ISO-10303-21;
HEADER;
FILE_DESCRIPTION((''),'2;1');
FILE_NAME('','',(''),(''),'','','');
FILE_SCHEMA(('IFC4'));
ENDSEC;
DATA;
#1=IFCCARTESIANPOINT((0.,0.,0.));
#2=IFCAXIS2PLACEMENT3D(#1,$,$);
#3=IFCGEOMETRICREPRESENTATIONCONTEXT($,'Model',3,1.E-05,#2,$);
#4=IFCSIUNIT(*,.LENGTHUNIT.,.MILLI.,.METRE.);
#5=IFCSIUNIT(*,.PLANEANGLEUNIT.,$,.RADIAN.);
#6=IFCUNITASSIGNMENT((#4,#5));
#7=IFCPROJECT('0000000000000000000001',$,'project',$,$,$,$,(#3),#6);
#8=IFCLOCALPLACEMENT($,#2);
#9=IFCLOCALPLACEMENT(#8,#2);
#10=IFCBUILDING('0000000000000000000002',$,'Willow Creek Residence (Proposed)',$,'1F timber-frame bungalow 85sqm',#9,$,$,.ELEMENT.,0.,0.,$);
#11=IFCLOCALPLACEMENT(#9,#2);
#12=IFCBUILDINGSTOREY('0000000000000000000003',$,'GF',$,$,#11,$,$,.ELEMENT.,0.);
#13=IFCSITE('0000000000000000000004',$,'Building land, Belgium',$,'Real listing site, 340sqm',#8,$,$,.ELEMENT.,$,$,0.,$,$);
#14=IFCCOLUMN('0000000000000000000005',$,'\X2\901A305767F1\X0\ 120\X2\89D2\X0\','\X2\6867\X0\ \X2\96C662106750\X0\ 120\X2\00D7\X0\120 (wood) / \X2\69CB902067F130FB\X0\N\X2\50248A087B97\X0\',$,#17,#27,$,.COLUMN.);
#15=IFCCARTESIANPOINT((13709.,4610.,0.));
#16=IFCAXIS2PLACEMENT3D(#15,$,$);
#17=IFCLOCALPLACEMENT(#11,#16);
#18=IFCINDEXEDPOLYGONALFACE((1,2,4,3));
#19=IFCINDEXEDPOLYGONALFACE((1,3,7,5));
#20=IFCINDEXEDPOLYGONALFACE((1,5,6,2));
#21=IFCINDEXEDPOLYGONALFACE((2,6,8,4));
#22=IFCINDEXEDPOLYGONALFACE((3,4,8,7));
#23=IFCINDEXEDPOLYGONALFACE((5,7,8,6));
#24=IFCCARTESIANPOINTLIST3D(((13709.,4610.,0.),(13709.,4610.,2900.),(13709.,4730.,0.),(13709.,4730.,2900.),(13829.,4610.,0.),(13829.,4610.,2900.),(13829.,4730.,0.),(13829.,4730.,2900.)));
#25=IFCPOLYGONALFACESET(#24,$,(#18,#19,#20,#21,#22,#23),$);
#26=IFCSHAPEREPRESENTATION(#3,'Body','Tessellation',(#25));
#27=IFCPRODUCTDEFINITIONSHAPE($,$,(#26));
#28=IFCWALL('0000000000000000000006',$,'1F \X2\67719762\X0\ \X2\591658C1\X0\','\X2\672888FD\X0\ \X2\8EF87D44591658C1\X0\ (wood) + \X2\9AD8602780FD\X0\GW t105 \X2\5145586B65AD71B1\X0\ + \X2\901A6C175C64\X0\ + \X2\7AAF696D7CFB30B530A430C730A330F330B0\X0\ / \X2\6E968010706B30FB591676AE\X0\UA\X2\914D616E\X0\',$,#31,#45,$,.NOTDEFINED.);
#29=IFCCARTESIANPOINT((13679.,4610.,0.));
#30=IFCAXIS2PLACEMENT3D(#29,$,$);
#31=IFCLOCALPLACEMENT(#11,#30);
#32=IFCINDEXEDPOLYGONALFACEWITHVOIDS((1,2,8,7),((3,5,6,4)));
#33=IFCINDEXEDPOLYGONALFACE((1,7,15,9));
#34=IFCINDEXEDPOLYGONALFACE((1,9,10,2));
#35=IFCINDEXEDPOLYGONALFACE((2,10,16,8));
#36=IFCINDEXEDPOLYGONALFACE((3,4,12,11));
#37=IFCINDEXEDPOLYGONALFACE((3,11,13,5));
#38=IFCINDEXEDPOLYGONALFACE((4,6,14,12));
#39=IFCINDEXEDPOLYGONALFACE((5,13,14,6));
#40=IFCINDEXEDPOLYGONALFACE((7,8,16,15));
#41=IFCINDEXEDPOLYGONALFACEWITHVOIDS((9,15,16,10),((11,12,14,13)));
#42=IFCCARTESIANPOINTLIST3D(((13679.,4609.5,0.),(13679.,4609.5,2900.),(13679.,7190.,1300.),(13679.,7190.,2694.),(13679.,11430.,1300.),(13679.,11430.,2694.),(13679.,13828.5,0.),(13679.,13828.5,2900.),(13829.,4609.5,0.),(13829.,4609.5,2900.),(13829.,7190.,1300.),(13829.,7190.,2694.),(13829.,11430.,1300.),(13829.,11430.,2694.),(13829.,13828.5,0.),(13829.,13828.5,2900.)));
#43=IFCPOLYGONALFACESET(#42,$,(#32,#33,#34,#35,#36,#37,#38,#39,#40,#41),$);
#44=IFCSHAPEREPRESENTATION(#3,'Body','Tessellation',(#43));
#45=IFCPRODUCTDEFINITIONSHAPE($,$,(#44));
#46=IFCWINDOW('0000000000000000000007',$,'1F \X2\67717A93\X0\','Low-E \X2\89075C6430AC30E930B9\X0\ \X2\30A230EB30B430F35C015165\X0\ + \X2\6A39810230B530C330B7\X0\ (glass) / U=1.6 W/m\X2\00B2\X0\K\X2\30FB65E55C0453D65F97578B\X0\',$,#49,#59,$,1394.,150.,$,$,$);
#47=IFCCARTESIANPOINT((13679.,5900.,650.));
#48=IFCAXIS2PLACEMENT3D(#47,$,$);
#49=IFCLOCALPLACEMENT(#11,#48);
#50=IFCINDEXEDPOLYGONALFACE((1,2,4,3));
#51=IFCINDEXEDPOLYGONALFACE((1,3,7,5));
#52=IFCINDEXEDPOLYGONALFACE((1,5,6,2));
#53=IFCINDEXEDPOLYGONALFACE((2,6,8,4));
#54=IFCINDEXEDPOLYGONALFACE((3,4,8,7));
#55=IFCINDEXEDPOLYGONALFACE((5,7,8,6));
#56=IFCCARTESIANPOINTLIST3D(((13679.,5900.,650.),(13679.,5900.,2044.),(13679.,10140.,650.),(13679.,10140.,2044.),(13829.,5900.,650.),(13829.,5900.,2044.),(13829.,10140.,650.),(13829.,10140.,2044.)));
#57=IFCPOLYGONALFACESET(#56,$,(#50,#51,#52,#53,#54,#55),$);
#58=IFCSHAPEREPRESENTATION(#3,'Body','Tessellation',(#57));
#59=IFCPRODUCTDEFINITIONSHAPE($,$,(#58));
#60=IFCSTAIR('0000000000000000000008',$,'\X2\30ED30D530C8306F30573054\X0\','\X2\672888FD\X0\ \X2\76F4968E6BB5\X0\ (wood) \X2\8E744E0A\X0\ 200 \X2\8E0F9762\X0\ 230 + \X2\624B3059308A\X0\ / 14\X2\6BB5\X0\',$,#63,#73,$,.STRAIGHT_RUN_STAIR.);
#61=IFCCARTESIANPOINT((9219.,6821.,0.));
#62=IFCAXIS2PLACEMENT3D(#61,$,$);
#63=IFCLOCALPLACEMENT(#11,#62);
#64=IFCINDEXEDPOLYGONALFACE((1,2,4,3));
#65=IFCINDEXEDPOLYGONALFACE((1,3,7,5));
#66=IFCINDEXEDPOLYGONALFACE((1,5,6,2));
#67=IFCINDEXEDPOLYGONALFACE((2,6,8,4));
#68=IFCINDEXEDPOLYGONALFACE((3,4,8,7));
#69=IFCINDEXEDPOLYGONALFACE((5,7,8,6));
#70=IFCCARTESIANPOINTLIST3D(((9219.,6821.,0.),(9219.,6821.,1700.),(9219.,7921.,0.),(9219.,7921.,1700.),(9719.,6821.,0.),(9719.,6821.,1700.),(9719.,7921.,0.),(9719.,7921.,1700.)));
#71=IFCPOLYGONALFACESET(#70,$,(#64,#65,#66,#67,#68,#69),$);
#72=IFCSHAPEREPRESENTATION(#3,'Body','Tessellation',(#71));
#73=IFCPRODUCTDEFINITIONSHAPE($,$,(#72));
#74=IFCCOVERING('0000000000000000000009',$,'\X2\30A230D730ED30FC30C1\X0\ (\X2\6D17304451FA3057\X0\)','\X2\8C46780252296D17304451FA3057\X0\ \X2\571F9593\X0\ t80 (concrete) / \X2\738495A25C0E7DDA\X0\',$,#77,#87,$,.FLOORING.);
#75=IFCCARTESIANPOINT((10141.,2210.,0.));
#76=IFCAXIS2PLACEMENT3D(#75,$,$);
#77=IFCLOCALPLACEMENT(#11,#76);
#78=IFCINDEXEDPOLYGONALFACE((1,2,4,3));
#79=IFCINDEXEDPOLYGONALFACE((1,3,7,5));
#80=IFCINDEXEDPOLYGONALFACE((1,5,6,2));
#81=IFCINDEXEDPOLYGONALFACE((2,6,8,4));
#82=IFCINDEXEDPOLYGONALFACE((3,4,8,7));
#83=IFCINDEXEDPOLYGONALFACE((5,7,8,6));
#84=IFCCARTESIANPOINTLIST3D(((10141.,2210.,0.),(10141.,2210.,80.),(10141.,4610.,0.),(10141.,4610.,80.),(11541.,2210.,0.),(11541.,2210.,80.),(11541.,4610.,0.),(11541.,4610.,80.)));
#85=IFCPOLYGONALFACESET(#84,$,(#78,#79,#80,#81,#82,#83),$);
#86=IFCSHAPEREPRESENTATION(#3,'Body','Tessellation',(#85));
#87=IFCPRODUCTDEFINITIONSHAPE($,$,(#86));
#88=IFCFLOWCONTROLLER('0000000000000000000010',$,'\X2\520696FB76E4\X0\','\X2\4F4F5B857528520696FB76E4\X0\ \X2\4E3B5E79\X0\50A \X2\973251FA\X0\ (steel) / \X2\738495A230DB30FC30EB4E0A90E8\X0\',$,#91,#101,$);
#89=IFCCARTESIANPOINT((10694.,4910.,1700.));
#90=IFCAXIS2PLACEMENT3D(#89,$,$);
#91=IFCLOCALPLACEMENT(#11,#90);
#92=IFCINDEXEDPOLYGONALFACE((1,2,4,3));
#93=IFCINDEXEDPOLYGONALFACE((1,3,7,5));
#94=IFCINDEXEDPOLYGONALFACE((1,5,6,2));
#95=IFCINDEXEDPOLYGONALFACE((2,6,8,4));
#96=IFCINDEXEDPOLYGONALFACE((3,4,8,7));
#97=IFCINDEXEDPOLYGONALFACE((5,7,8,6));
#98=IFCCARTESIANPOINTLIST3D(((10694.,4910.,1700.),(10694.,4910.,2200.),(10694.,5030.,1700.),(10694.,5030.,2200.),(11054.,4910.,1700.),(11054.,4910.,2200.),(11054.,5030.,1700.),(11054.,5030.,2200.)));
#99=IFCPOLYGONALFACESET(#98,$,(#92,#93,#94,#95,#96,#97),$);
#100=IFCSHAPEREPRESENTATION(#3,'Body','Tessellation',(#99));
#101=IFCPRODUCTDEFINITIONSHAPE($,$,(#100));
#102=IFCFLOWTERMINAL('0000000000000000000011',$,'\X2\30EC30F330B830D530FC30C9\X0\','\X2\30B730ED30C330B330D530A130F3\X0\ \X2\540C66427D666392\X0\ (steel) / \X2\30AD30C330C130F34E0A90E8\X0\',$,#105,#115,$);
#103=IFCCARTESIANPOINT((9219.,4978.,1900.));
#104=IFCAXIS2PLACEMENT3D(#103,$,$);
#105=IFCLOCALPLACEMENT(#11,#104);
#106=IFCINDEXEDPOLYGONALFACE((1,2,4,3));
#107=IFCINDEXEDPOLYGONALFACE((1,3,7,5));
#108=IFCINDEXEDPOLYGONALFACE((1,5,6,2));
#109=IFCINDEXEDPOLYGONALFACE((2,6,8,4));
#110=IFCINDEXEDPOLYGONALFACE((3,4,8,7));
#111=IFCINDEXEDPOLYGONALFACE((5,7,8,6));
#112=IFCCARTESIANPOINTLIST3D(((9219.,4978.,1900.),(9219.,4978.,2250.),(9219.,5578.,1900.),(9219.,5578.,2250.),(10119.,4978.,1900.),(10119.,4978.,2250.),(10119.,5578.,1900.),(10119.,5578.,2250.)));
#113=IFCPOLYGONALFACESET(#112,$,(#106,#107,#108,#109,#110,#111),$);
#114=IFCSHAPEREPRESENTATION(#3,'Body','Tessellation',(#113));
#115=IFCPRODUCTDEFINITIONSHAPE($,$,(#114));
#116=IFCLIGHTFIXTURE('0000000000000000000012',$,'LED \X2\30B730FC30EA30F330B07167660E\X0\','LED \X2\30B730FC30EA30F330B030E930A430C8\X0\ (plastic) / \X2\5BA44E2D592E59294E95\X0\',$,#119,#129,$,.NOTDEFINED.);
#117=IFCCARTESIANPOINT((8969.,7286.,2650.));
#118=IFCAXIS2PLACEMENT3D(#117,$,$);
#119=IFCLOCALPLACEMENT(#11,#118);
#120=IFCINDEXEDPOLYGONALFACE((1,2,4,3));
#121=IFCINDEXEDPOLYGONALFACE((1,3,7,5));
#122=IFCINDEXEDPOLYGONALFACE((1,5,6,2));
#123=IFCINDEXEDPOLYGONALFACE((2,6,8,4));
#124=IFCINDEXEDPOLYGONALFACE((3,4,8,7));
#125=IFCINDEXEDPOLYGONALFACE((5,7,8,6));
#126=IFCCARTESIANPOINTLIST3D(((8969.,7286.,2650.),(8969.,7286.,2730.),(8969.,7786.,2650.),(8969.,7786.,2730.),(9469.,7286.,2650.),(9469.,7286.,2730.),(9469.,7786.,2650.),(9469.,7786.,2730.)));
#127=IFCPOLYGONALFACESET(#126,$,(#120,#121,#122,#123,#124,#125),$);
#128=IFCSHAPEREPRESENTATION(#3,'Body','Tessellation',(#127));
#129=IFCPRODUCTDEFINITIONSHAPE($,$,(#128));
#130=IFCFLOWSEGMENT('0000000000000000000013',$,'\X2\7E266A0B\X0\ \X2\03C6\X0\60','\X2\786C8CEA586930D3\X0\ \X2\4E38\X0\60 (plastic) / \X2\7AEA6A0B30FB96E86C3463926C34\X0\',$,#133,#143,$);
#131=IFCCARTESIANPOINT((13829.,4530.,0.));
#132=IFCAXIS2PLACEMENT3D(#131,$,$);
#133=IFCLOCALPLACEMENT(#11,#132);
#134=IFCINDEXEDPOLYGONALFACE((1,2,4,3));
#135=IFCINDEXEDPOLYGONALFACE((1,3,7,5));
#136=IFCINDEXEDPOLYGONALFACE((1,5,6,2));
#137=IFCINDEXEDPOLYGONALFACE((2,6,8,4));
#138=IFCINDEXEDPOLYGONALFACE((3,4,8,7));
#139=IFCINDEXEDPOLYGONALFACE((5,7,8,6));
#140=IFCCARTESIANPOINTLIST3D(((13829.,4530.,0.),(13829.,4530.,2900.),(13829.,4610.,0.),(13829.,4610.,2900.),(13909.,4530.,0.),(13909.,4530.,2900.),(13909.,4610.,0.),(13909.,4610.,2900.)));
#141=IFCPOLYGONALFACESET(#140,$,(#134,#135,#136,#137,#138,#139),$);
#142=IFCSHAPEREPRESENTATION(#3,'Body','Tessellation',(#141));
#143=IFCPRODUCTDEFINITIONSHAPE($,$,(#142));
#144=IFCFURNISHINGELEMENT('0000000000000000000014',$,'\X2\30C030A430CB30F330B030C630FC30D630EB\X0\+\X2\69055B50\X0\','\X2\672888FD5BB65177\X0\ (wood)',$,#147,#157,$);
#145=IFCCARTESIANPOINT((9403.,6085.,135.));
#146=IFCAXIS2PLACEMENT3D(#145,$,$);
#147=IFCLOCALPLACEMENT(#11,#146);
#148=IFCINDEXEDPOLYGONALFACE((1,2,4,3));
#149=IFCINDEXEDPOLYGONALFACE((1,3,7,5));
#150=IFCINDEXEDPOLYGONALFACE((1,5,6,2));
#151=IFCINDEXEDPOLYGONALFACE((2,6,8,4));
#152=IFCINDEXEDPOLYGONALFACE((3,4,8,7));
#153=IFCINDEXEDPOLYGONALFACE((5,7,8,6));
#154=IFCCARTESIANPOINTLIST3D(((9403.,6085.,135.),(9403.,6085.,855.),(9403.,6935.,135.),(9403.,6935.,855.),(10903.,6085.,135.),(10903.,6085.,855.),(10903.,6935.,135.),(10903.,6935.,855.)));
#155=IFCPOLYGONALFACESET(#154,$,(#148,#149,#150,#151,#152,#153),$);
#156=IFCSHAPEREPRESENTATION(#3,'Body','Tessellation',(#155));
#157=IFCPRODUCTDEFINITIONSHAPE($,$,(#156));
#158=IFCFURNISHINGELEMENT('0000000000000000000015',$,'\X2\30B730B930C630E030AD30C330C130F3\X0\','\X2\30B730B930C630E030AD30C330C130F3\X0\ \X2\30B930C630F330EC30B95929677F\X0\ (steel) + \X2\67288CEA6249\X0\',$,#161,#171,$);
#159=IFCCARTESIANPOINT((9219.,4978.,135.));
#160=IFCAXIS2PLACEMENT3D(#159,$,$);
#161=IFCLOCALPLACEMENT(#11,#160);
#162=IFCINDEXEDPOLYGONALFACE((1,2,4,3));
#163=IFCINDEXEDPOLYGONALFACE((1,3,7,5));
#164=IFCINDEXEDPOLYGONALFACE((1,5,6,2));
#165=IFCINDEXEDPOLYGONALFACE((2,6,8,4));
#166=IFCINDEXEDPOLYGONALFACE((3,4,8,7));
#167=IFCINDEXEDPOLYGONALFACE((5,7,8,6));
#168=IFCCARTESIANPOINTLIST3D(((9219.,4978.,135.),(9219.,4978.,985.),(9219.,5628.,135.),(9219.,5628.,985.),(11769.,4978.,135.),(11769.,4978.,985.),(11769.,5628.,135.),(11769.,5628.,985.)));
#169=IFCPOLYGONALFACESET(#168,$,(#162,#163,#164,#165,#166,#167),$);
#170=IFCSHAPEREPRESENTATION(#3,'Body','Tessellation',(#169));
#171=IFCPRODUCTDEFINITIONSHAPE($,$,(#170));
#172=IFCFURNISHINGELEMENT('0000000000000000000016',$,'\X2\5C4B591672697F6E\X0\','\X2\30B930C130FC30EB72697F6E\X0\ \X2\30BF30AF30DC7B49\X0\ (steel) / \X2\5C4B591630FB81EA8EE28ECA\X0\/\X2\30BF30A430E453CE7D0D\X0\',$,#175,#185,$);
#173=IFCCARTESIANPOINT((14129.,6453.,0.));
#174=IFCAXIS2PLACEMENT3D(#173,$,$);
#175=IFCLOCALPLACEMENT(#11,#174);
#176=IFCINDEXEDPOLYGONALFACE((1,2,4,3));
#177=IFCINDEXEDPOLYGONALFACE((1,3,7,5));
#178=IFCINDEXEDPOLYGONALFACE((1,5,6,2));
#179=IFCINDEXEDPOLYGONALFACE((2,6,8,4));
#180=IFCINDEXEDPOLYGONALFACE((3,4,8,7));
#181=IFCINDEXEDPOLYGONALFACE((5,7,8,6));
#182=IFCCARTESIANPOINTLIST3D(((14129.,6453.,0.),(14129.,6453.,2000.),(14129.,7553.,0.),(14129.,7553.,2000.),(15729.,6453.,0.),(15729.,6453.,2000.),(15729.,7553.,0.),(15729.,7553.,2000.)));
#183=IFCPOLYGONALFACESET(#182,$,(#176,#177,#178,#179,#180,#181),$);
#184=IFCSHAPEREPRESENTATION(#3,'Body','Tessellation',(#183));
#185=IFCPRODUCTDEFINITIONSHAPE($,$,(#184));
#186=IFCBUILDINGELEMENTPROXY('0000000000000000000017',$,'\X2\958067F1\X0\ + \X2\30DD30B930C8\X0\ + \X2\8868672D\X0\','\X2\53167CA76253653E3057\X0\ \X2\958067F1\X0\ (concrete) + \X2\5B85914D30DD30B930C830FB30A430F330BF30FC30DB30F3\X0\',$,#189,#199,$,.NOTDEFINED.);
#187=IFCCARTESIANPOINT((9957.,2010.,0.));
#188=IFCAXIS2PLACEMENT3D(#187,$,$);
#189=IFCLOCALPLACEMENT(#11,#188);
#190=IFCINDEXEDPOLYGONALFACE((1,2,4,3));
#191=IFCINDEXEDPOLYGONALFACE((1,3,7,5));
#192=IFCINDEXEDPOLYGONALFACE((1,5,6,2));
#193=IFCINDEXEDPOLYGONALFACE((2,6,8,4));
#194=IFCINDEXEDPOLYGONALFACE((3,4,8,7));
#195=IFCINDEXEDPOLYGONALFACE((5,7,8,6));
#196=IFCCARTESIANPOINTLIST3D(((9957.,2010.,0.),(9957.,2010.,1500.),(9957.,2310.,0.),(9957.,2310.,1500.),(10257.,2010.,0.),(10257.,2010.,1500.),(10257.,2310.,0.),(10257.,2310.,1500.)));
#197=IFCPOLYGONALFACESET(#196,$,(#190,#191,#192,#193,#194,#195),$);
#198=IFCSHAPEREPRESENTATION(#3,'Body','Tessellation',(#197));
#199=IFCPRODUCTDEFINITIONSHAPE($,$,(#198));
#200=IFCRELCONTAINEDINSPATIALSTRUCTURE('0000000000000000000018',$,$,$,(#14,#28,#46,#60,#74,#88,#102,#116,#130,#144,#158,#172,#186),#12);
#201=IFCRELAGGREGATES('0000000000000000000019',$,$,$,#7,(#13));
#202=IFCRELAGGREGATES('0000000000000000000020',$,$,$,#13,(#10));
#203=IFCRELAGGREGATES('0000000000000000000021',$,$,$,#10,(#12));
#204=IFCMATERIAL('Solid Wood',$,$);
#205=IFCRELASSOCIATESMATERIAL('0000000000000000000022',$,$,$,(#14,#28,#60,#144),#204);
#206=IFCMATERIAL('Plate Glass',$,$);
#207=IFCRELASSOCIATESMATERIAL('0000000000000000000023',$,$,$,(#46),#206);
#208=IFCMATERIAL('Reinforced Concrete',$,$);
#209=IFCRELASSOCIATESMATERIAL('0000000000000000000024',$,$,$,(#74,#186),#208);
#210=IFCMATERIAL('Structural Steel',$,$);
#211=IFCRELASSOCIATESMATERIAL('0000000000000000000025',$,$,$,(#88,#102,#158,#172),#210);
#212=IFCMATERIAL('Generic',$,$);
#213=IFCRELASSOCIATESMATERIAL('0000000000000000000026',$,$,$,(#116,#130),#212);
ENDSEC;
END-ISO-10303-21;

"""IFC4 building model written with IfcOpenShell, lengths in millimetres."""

from ifc_helpers import new_model, si_unit, frame, frame_2d, origin, place, context, project, spatial, rectangle, extrude, material, element, fill, save


model = new_model("IFC4")

# Units and contexts
model_context = context("Model", 3, precision=1e-05, world=origin())
ifc_project = project(units=[si_unit("LENGTHUNIT", "METRE", prefix="MILLI"), si_unit("PLANEANGLEUNIT", "RADIAN")], contexts=[model_context])

# Site, building, storey
site_placement = place(None, origin())
site = spatial("IfcSite", under=ifc_project, at=site_placement, Name="Building land, Belgium", ObjectType="Real listing site, 340sqm", CompositionType="ELEMENT", RefElevation=0.0)
building_placement = place(site_placement, origin())
building = spatial("IfcBuilding", under=site, at=building_placement, Name="Willow Creek Residence (Proposed)", ObjectType="1F timber-frame bungalow 85sqm", CompositionType="ELEMENT", ElevationOfRefHeight=0.0, ElevationOfTerrain=0.0)
storey_placement = place(building_placement, origin())
storey = spatial("IfcBuildingStorey", under=building, at=storey_placement, Name="GF", CompositionType="ELEMENT", Elevation=0.0)

# Column
ifc_material_1 = material(Name="Solid Wood")
column_1_placement = place(storey_placement, frame((13709.0, 4610.0, 0.0)))
element("IfcColumn", 1, at=column_1_placement, inside=storey, material=ifc_material_1, Name="通し柱 120角", Description="桧 集成材 120×120 (wood) / 構造柱・N値計算", PredefinedType="COLUMN", context=model_context, shape_type="SweptSolid", body=[
    extrude(rectangle(XDim=120.0, YDim=120.0, at=frame_2d((60.0, 60.0))), frame((13709.0, 4610.0, 0.0)), (0.0, 0.0, 1.0), 2900.0),
])

# Wall, opening, window
wall_1_placement = place(storey_placement, frame((13679.0, 4610.0, 0.0)))
wall_1 = element("IfcWall", 2, at=wall_1_placement, inside=storey, material=ifc_material_1, Name="1F 東面 外壁", Description="木製 軸組外壁 (wood) + 高性能GW t105 充填断熱 + 通気層 + 窯業系サイディング / 準耐火・外皮UA配慮", PredefinedType="NOTDEFINED", context=model_context, shape_type="SweptSolid", body=[
    extrude(rectangle(XDim=150.0, YDim=9219.0, at=frame_2d((75.0, 4609.0))), frame((13679.0, 4610.0, 0.0)), (0.0, 0.0, 1.0), 2900.0),
])
opening_placement = place(storey_placement, frame((13679.0, 5900.0, 650.0)))
opening = element("IfcOpeningElement", 3, at=opening_placement, cuts=wall_1, PredefinedType="NOTDEFINED", context=model_context, shape_type="SweptSolid", body=[
    extrude(rectangle(XDim=150.0, YDim=4240.0, at=frame_2d((75.0, 2120.0))), frame((13679.0, 5900.0, 650.0)), (0.0, 0.0, 1.0), 1394.0),
])
ifc_material_2 = material(Name="Plate Glass")
window_placement = place(storey_placement, frame((13679.0, 5900.0, 650.0)))
window = element("IfcWindow", 4, at=window_placement, inside=storey, material=ifc_material_2, Name="1F 東窓", Description="Low-E 複層ガラス アルゴン封入 + 樹脂サッシ (glass) / U=1.6 W/m²K・日射取得型", OverallHeight=1394.0, OverallWidth=150.0, context=model_context, shape_type="SweptSolid", body=[
    extrude(rectangle(XDim=150.0, YDim=4240.0, at=frame_2d((75.0, 2120.0))), frame((13679.0, 5900.0, 650.0)), (0.0, 0.0, 1.0), 1394.0),
])
fill(opening, window)

# Stair
stair_placement = place(storey_placement, frame((9219.0, 6821.0, 0.0)))
element("IfcStair", 5, at=stair_placement, inside=storey, material=ifc_material_1, Name="ロフトはしご", Description="木製 直階段 (wood) 蹴上 200 踏面 230 + 手すり / 14段", PredefinedType="STRAIGHT_RUN_STAIR", context=model_context, shape_type="SweptSolid", body=[
    extrude(rectangle(XDim=500.0, YDim=1100.0, at=frame_2d((250.0, 550.0))), frame((9219.0, 6821.0, 0.0)), (0.0, 0.0, 1.0), 1700.0),
])

# Covering
ifc_material_3 = material(Name="Reinforced Concrete")
covering_placement = place(storey_placement, frame((10141.0, 2210.0, 0.0)))
element("IfcCovering", 6, at=covering_placement, inside=storey, material=ifc_material_3, Name="アプローチ (洗い出し)", Description="豆砂利洗い出し 土間 t80 (concrete) / 玄関導線", PredefinedType="FLOORING", context=model_context, shape_type="SweptSolid", body=[
    extrude(rectangle(XDim=1400.0, YDim=2400.0, at=frame_2d((700.0, 1200.0))), frame((10141.0, 2210.0, 0.0)), (0.0, 0.0, 1.0), 80.0),
])

# Flow controller
ifc_material_4 = material(Name="Structural Steel")
flow_controller_placement = place(storey_placement, frame((10694.0, 4910.0, 1700.0)))
element("IfcFlowController", 7, at=flow_controller_placement, inside=storey, material=ifc_material_4, Name="分電盤", Description="住宅用分電盤 主幹50A 露出 (steel) / 玄関ホール上部", context=model_context, shape_type="SweptSolid", body=[
    extrude(rectangle(XDim=360.0, YDim=120.0, at=frame_2d((180.0, 60.0))), frame((10694.0, 4910.0, 1700.0)), (0.0, 0.0, 1.0), 500.0),
])

# Flow terminal
flow_terminal_placement = place(storey_placement, frame((9219.0, 4978.0, 1900.0)))
element("IfcFlowTerminal", 8, at=flow_terminal_placement, inside=storey, material=ifc_material_4, Name="レンジフード", Description="シロッコファン 同時給排 (steel) / キッチン上部", context=model_context, shape_type="SweptSolid", body=[
    extrude(rectangle(XDim=900.0, YDim=600.0, at=frame_2d((450.0, 300.0))), frame((9219.0, 4978.0, 1900.0)), (0.0, 0.0, 1.0), 350.0),
])

# Light fixture
ifc_material_5 = material(Name="Generic")
light_fixture_placement = place(storey_placement, frame((8969.0, 7286.0, 2650.0)))
element("IfcLightFixture", 9, at=light_fixture_placement, inside=storey, material=ifc_material_5, Name="LED シーリング照明", Description="LED シーリングライト (plastic) / 室中央天井", PredefinedType="NOTDEFINED", context=model_context, shape_type="SweptSolid", body=[
    extrude(rectangle(XDim=500.0, YDim=500.0, at=frame_2d((250.0, 250.0))), frame((8969.0, 7286.0, 2650.0)), (0.0, 0.0, 1.0), 80.0),
])

# Flow segment
flow_segment_placement = place(storey_placement, frame((13829.0, 4530.0, 0.0)))
element("IfcFlowSegment", 10, at=flow_segment_placement, inside=storey, material=ifc_material_5, Name="縦樋 φ60", Description="硬質塩ビ 丸60 (plastic) / 竪樋・雨水排水", context=model_context, shape_type="SweptSolid", body=[
    extrude(rectangle(XDim=80.0, YDim=80.0, at=frame_2d((40.0, 40.0))), frame((13829.0, 4530.0, 0.0)), (0.0, 0.0, 1.0), 2900.0),
])

# Furnishing elements
furnishing_1_placement = place(storey_placement, frame((9403.0, 6085.0, 135.0)))
element("IfcFurnishingElement", 11, at=furnishing_1_placement, inside=storey, material=ifc_material_1, Name="ダイニングテーブル+椅子", Description="木製家具 (wood)", context=model_context, shape_type="SweptSolid", body=[
    extrude(rectangle(XDim=1500.0, YDim=850.0, at=frame_2d((750.0, 425.0))), frame((9403.0, 6085.0, 135.0)), (0.0, 0.0, 1.0), 720.0),
])
furnishing_2_placement = place(storey_placement, frame((9219.0, 4978.0, 135.0)))
element("IfcFurnishingElement", 12, at=furnishing_2_placement, inside=storey, material=ifc_material_4, Name="システムキッチン", Description="システムキッチン ステンレス天板 (steel) + 木質扉", context=model_context, shape_type="SweptSolid", body=[
    extrude(rectangle(XDim=2550.0, YDim=650.0, at=frame_2d((1275.0, 325.0))), frame((9219.0, 4978.0, 135.0)), (0.0, 0.0, 1.0), 850.0),
])
furnishing_3_placement = place(storey_placement, frame((14129.0, 6453.0, 0.0)))
element("IfcFurnishingElement", 13, at=furnishing_3_placement, inside=storey, material=ifc_material_4, Name="屋外物置", Description="スチール物置 タクボ等 (steel) / 屋外・自転車/タイヤ収納", context=model_context, shape_type="SweptSolid", body=[
    extrude(rectangle(XDim=1600.0, YDim=1100.0, at=frame_2d((800.0, 550.0))), frame((14129.0, 6453.0, 0.0)), (0.0, 0.0, 1.0), 2000.0),
])

# Building element proxy
proxy_placement = place(storey_placement, frame((9957.0, 2010.0, 0.0)))
element("IfcBuildingElementProxy", 14, at=proxy_placement, inside=storey, material=ifc_material_3, Name="門柱 + ポスト + 表札", Description="化粧打放し 門柱 (concrete) + 宅配ポスト・インターホン", PredefinedType="NOTDEFINED", context=model_context, shape_type="SweptSolid", body=[
    extrude(rectangle(XDim=300.0, YDim=300.0, at=frame_2d((150.0, 150.0))), frame((9957.0, 2010.0, 0.0)), (0.0, 0.0, 1.0), 1500.0),
])

save(model, "model.ifc")
